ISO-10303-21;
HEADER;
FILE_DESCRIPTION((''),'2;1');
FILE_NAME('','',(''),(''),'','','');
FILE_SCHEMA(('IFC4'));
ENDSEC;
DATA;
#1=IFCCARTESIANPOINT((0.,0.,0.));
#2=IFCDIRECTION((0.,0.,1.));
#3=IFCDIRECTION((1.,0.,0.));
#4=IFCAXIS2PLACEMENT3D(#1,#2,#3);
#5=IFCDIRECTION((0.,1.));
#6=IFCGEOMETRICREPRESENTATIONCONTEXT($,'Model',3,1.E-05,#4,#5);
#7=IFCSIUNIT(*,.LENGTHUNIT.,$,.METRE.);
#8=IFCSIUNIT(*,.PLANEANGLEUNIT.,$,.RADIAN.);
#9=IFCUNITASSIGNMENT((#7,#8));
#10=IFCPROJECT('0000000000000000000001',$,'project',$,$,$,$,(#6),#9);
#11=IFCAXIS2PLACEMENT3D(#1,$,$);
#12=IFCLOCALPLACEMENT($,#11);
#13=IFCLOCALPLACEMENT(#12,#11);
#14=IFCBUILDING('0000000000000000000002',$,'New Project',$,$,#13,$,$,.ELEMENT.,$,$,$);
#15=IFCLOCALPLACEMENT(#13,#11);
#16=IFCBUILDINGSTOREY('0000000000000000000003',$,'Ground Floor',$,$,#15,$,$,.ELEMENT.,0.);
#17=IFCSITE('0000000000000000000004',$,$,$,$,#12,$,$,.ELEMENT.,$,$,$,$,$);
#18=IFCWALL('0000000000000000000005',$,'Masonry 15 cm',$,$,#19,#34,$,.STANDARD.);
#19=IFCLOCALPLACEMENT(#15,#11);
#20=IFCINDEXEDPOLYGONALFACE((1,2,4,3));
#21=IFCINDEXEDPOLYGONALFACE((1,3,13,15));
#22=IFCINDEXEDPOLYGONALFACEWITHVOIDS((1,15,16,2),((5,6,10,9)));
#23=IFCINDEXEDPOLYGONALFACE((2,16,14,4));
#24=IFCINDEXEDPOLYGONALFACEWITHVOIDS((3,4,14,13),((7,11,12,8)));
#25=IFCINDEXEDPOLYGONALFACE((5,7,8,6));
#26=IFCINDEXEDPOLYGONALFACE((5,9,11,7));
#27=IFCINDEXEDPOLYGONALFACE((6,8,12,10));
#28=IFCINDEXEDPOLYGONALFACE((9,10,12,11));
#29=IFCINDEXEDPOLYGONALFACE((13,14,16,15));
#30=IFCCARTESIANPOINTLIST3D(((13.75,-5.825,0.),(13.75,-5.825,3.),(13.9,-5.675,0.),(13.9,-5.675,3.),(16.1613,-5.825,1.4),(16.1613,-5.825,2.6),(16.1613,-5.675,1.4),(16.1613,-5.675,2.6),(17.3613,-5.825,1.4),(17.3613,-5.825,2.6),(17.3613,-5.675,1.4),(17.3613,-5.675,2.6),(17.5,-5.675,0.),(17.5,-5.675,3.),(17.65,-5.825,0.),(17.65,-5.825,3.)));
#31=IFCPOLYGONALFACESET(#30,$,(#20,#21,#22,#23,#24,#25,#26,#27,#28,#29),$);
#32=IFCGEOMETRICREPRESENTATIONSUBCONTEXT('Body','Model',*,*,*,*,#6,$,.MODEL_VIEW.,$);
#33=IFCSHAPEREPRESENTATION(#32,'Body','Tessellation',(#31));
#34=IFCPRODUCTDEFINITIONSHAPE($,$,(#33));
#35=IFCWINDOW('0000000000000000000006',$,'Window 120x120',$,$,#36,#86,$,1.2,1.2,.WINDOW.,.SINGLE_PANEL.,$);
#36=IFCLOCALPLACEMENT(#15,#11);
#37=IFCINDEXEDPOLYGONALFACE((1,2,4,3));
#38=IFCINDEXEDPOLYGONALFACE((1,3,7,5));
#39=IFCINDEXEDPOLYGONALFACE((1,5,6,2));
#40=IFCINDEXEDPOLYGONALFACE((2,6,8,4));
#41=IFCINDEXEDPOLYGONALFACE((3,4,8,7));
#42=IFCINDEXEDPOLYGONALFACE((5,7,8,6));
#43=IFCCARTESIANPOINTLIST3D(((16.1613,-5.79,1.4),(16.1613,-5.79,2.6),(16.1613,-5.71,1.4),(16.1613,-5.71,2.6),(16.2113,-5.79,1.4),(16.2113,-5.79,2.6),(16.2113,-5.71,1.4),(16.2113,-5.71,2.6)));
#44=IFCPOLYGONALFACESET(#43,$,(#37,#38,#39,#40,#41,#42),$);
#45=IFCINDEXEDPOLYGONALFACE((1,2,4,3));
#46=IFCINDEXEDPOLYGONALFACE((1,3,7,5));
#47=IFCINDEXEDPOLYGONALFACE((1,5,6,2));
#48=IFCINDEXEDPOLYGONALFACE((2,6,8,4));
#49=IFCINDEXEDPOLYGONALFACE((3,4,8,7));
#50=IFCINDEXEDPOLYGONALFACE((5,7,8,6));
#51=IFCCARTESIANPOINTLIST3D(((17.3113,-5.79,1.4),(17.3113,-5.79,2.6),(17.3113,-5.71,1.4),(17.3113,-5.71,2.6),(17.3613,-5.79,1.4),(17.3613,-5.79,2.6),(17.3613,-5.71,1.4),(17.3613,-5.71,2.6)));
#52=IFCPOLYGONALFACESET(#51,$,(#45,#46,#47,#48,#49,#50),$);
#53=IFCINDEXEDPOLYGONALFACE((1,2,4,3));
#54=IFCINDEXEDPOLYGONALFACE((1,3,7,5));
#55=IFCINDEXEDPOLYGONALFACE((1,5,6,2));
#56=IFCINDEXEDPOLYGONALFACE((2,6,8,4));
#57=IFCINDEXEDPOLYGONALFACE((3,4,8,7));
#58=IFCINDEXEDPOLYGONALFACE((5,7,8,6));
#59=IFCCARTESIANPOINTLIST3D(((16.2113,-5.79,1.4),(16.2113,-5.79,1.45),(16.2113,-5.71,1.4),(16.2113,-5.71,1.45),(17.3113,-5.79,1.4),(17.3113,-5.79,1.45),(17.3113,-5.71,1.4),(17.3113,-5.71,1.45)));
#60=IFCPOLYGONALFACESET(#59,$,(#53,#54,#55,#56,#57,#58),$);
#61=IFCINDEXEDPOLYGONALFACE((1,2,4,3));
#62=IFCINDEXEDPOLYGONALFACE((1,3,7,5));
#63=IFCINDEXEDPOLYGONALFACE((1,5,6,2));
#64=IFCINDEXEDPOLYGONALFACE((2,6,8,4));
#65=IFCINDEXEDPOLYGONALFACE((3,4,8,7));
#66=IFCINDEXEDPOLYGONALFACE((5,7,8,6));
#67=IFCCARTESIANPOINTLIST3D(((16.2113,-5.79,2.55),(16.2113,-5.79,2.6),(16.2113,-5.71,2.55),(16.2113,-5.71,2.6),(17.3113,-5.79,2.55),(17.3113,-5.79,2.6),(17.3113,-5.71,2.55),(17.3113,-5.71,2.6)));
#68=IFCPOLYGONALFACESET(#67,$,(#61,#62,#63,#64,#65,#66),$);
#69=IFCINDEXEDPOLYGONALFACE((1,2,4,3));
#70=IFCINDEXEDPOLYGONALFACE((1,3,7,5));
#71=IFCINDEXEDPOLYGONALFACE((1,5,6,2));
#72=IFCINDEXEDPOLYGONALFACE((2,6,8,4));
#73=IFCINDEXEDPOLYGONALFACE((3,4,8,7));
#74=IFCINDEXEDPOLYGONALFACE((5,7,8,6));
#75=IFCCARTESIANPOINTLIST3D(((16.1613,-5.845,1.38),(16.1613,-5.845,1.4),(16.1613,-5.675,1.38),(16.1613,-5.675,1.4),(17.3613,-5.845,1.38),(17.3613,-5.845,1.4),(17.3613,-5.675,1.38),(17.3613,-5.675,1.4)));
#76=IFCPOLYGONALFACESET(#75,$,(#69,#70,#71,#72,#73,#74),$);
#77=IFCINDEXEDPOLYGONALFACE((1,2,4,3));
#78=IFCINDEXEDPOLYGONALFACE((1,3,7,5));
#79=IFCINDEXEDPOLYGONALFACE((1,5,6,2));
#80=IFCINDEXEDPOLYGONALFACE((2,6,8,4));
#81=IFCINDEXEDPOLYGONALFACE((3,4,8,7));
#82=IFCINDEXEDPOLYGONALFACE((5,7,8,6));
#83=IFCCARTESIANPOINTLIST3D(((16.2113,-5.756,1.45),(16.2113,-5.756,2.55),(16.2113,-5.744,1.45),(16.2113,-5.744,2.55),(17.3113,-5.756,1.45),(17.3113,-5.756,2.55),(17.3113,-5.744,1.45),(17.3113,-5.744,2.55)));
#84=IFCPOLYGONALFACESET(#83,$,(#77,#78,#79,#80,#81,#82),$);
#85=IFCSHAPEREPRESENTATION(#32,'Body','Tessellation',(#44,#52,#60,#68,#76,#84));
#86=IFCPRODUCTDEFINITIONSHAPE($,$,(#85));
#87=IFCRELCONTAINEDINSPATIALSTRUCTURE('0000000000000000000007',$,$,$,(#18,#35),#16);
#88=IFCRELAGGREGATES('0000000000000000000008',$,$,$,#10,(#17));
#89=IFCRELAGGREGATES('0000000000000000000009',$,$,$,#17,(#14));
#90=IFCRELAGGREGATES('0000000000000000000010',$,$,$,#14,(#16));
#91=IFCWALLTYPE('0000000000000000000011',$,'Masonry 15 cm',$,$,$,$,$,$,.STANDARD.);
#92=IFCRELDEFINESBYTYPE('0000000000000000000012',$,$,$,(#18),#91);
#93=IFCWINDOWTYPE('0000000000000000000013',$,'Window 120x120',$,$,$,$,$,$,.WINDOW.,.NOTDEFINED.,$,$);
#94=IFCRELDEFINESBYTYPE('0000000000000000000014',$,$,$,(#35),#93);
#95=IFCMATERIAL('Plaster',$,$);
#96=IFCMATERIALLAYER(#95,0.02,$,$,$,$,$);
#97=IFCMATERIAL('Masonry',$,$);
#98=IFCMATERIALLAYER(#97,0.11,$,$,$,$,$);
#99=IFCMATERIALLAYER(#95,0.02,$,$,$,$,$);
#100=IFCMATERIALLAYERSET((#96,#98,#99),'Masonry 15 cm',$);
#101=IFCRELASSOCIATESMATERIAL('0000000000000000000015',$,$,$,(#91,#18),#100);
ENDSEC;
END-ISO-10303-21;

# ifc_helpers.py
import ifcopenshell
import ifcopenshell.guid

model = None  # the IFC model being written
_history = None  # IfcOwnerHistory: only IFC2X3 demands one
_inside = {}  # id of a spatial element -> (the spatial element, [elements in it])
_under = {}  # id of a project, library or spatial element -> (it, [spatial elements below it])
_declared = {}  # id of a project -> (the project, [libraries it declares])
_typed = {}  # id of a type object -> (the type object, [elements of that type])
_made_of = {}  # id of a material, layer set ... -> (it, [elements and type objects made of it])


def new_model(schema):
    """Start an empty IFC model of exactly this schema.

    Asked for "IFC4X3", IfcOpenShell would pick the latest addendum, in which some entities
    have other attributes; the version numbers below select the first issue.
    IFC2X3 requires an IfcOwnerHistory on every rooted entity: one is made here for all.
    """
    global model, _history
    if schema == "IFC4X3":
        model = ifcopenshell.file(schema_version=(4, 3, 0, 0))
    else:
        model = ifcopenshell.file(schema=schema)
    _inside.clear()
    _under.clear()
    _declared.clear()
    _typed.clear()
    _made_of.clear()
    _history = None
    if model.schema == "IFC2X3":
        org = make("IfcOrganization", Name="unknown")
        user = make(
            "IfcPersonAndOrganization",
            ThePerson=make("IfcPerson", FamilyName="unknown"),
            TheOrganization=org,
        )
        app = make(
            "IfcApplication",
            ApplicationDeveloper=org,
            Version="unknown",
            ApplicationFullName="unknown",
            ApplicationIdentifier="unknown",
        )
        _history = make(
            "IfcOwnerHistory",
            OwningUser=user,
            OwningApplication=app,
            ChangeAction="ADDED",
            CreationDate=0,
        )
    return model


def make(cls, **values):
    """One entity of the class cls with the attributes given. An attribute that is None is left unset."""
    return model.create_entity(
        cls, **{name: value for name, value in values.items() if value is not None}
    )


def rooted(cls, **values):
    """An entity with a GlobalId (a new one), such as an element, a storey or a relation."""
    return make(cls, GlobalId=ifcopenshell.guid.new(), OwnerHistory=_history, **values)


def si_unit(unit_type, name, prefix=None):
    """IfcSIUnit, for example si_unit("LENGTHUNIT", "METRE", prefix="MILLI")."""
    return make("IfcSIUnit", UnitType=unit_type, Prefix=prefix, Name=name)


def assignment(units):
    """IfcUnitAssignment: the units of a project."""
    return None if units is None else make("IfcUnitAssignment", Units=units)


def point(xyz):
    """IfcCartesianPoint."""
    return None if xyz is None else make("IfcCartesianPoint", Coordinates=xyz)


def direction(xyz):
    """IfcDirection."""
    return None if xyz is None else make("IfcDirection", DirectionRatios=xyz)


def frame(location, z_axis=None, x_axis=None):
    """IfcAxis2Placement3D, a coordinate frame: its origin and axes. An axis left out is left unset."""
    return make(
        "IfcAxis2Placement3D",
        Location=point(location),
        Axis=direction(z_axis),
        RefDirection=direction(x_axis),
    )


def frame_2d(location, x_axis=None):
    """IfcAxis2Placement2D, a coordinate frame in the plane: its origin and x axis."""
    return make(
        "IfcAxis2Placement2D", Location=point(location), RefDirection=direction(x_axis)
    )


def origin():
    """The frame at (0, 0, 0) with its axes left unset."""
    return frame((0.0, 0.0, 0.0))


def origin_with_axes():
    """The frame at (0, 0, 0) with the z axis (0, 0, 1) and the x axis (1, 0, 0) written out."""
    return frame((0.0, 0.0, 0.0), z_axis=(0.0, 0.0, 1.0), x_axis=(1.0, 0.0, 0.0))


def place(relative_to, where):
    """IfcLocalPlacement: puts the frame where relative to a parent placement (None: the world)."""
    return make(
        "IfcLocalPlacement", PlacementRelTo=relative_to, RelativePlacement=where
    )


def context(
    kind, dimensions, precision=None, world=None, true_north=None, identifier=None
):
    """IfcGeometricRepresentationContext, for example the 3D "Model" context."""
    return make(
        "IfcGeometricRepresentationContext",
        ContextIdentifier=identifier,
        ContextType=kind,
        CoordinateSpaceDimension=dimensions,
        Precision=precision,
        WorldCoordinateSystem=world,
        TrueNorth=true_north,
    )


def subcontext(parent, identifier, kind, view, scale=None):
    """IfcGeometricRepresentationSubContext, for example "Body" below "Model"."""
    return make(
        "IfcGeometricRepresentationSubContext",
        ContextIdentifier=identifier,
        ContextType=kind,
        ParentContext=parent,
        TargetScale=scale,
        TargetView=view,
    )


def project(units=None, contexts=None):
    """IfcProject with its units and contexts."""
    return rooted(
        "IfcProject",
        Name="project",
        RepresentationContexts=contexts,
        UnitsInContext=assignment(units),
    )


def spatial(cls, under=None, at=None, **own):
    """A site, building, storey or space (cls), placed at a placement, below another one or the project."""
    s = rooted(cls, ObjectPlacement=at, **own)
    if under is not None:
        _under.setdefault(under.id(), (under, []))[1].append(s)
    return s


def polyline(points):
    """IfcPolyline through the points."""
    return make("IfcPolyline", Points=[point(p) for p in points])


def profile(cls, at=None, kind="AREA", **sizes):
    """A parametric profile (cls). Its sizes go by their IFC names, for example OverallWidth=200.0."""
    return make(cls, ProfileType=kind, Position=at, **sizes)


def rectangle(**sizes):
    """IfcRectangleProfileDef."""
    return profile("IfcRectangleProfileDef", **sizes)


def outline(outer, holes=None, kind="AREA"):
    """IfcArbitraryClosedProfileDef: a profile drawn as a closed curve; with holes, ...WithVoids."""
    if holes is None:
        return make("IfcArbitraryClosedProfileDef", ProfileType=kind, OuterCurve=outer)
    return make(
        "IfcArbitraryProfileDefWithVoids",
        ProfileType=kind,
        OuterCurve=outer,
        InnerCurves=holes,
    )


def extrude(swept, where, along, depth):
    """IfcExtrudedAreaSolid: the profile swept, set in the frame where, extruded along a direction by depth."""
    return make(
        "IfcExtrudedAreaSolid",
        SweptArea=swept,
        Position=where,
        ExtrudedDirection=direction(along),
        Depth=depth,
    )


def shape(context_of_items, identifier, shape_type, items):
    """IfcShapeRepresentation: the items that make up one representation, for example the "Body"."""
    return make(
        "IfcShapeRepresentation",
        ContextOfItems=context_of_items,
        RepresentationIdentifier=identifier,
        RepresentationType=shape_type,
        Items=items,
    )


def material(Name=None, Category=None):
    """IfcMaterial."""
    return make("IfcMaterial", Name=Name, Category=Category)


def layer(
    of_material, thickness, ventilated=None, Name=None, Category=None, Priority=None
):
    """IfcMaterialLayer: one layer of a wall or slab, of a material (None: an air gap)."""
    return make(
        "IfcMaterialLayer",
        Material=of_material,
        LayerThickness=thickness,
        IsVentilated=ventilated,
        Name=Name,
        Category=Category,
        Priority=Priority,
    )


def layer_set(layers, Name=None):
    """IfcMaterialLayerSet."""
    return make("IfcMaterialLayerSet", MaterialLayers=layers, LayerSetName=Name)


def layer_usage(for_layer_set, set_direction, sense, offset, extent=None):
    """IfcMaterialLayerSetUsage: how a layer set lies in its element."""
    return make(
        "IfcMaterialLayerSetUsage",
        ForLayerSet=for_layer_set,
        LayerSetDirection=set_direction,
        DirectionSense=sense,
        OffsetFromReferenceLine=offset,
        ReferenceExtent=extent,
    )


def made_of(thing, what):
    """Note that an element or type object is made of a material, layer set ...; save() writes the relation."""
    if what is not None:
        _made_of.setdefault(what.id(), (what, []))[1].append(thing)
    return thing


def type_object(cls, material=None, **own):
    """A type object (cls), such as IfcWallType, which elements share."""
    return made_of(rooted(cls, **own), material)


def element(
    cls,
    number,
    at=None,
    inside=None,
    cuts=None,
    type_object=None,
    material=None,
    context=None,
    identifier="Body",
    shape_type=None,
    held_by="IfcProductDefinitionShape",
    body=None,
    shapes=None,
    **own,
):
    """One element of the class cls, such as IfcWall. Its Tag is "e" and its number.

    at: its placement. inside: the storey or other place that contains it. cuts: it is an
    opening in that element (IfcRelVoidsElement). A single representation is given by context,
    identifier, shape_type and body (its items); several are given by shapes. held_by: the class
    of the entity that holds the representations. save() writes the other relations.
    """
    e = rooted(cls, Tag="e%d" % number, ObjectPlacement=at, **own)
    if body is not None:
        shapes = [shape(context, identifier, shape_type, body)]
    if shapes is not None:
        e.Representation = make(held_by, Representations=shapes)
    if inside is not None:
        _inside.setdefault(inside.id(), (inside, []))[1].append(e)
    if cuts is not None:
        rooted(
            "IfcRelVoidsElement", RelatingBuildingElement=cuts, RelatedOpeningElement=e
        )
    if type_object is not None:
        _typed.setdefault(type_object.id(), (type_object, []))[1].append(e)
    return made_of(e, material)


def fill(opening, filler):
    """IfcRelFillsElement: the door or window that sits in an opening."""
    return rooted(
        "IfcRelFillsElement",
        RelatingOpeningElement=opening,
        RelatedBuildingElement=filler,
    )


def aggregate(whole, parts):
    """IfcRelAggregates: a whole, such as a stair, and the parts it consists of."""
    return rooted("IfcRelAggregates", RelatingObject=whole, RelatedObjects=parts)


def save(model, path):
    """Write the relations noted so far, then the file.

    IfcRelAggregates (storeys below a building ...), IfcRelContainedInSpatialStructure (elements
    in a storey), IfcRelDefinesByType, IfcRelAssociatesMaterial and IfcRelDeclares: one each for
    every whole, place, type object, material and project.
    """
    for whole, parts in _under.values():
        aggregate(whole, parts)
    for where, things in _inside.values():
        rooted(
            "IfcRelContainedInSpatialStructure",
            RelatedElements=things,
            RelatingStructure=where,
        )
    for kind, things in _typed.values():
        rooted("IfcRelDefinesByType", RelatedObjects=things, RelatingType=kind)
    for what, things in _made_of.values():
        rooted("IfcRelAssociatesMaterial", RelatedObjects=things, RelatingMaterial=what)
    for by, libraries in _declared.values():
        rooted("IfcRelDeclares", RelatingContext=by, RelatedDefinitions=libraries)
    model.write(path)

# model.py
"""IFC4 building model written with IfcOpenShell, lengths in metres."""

from ifc_helpers import new_model, si_unit, direction, frame, frame_2d, origin, origin_with_axes, place, context, subcontext, project, spatial, polyline, rectangle, outline, extrude, material, layer, layer_set, layer_usage, type_object, element, fill, save


model = new_model("IFC4")

# Units and contexts
model_context = context("Model", 3, precision=1e-05, world=origin_with_axes(), true_north=direction((0.0, 1.0)))
body_context = subcontext(model_context, "Body", "Model", "MODEL_VIEW")
ifc_project = project(units=[si_unit("LENGTHUNIT", "METRE"), si_unit("PLANEANGLEUNIT", "RADIAN")], contexts=[model_context])

# Site, building, storey
site_placement = place(None, origin())
site = spatial("IfcSite", under=ifc_project, at=site_placement, CompositionType="ELEMENT")
building_placement = place(site_placement, origin())
building = spatial("IfcBuilding", under=site, at=building_placement, Name="New Project", CompositionType="ELEMENT")
storey_placement = place(building_placement, origin())
storey = spatial("IfcBuildingStorey", under=building, at=storey_placement, Name="Ground Floor", CompositionType="ELEMENT", Elevation=0.0)

# Shared definitions
ifc_material_1 = material(Name="Plaster")
ifc_layer_1 = layer(ifc_material_1, 0.02)
ifc_material_2 = material(Name="Masonry")
ifc_layer_2 = layer(ifc_material_2, 0.11)
ifc_layer_3 = layer(ifc_material_1, 0.02)
ifc_layer_set_1 = layer_set([ifc_layer_1, ifc_layer_2, ifc_layer_3], Name="Masonry 15 cm")
ifc_layer_usage_1 = layer_usage(ifc_layer_set_1, "AXIS2", "NEGATIVE", 0.075)
wall_type_1 = type_object("IfcWallType", Name="Masonry 15 cm", PredefinedType="STANDARD", material=ifc_layer_set_1)
window_type_1 = type_object("IfcWindowType", Name="Window 120x120", PartitioningType="NOTDEFINED", PredefinedType="WINDOW")

# Wall, opening, window
wall_1_placement = place(storey_placement, frame((17.575, -5.75, 0.0), z_axis=(0.0, 0.0, 1.0), x_axis=(-1.0, 0.0, 0.0)))
wall_1 = element("IfcWall", 1, at=wall_1_placement, inside=storey, type_object=wall_type_1, material=ifc_layer_usage_1, Name="Masonry 15 cm", PredefinedType="STANDARD", context=body_context, shape_type="SweptSolid", body=[
    extrude(outline(polyline([(0.075, -0.075), (3.675, -0.075), (3.825, 0.075), (-0.075, 0.075), (0.075, -0.075)])), origin(), (0.0, 0.0, 1.0), 3.0),
])
opening_1_placement = place(wall_1_placement, frame((0.2137, 0.0, 1.4)))
opening_1 = element("IfcOpeningElement", 2, at=opening_1_placement, cuts=wall_1, PredefinedType="OPENING", context=body_context, shape_type="SweptSolid", body=[
    extrude(rectangle(XDim=1.2, YDim=0.25, at=frame_2d((0.6, 0.0))), origin(), (0.0, 0.0, 1.0), 1.2),
])
window_1_placement = place(opening_1_placement, origin())
window_1 = element("IfcWindow", 3, at=window_1_placement, inside=storey, type_object=window_type_1, Name="Window 120x120", OverallHeight=1.2, OverallWidth=1.2, PartitioningType="SINGLE_PANEL", PredefinedType="WINDOW", context=body_context, shape_type="SweptSolid", body=[
    extrude(outline(polyline([(1.2, 0.04), (1.15, 0.04), (1.15, -0.04), (1.2, -0.04), (1.2, 0.04)])), origin(), (0.0, 0.0, 1.0), 1.2),
    extrude(outline(polyline([(0.05, 0.04), (0.0, 0.04), (0.0, -0.04), (0.05, -0.04), (0.05, 0.04)])), origin(), (0.0, 0.0, 1.0), 1.2),
    extrude(outline(polyline([(1.15, 0.04), (0.05, 0.04), (0.05, -0.04), (1.15, -0.04), (1.15, 0.04)])), origin(), (0.0, 0.0, 1.0), 0.05),
    extrude(outline(polyline([(1.15, 0.04), (0.05, 0.04), (0.05, -0.04), (1.15, -0.04), (1.15, 0.04)])), frame((0.0, 0.0, 1.15)), (0.0, 0.0, 1.0), 0.05),
    extrude(outline(polyline([(1.2, 0.095), (0.0, 0.095), (0.0, -0.075), (1.2, -0.075), (1.2, 0.095)])), frame((0.0, 0.0, -0.02)), (0.0, 0.0, 1.0), 0.02),
    extrude(outline(polyline([(1.15, 0.006), (0.05, 0.006), (0.05, -0.006), (1.15, -0.006), (1.15, 0.006)])), frame((0.0, 0.0, 0.05)), (0.0, 0.0, 1.0), 1.1),
])
fill(opening_1, window_1)

save(model, "model.ifc")
